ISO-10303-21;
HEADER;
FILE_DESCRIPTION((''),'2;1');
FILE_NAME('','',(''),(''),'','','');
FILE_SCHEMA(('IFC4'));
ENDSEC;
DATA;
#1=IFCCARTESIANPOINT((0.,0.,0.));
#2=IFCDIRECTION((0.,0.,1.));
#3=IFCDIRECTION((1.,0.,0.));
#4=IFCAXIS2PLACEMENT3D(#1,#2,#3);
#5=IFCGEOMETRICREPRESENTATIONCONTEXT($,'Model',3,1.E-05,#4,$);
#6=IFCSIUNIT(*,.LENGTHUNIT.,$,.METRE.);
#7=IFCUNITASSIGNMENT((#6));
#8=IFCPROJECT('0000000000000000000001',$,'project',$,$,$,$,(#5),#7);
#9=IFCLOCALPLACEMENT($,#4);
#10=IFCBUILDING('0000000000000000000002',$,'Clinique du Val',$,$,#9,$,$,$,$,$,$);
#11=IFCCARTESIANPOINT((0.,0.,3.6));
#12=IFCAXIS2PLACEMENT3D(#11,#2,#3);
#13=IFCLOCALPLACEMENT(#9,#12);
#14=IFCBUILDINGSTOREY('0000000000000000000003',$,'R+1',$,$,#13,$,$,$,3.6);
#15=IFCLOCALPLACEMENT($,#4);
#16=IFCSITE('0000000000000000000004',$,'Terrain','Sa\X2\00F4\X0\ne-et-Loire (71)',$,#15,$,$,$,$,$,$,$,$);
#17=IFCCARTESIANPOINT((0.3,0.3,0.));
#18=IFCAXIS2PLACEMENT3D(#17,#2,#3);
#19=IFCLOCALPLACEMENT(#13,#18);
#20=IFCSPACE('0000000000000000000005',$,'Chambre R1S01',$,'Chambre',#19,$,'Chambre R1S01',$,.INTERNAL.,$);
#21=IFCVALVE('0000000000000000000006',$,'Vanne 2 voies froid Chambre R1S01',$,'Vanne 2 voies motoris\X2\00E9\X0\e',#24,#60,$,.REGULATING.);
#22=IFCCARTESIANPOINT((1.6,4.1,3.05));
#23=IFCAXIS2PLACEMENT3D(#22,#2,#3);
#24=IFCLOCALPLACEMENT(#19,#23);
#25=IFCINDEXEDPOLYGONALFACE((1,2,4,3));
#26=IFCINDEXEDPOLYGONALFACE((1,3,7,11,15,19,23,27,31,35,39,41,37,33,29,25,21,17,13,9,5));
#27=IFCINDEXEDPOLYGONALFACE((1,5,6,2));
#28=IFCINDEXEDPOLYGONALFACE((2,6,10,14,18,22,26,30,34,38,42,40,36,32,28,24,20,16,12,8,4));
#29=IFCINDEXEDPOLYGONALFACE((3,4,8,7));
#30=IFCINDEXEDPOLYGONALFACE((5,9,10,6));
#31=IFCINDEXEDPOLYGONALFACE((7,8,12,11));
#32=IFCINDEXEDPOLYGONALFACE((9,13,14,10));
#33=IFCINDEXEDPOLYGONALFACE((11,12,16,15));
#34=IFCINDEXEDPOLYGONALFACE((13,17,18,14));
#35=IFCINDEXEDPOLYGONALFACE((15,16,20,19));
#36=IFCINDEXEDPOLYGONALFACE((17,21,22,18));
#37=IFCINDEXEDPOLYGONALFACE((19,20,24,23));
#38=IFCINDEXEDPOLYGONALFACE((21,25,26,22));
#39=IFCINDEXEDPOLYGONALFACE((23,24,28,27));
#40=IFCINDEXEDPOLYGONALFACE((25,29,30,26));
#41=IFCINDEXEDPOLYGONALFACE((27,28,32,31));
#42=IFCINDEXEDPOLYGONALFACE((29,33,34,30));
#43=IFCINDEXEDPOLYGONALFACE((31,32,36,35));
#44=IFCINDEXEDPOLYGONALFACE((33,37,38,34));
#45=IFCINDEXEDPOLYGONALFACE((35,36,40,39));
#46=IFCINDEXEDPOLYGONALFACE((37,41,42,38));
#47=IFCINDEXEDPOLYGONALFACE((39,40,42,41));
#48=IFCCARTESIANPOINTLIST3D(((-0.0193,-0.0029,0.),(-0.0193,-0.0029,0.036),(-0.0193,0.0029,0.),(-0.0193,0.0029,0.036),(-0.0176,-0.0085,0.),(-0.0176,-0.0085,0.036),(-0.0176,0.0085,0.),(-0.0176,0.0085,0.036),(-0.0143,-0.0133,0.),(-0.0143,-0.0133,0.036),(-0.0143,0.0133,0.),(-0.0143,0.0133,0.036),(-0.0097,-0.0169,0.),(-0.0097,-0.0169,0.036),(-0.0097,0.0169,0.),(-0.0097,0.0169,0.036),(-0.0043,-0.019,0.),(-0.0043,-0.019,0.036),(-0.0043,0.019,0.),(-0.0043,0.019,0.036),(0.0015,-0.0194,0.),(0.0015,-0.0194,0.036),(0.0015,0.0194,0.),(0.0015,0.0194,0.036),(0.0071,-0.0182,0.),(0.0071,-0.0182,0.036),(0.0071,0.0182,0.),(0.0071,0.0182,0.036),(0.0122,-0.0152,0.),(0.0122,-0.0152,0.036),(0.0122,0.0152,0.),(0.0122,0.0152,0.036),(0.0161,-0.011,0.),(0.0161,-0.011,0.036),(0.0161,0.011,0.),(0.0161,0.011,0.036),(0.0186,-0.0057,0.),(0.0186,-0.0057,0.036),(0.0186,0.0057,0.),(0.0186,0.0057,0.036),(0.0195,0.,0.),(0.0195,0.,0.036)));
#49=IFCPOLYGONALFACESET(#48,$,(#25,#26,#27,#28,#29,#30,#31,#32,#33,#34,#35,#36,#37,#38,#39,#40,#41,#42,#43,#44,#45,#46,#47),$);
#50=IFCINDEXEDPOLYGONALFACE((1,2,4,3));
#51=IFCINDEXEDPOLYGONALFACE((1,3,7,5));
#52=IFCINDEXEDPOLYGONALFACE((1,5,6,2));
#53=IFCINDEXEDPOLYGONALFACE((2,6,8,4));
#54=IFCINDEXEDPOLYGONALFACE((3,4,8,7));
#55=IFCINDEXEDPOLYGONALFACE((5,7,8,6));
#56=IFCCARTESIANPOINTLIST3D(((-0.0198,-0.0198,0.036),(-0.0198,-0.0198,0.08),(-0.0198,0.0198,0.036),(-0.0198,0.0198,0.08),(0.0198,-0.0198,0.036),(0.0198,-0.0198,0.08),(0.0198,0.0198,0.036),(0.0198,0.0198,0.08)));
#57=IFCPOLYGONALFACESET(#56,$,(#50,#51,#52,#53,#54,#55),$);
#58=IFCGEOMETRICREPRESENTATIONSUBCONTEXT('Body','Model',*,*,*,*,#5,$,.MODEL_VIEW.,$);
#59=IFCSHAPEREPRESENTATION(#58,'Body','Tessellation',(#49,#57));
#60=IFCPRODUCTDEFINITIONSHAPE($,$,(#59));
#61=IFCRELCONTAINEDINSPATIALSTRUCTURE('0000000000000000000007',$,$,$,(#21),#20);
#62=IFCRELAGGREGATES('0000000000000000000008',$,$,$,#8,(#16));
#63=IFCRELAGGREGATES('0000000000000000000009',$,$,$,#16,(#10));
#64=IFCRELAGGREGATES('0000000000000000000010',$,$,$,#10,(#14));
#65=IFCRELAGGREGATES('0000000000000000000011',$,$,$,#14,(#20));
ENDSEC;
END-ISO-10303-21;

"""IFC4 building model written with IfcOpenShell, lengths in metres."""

from ifc_helpers import new_model, si_unit, frame, frame_2d, origin_with_axes, place, context, subcontext, project, spatial, rectangle, circle, extrude, element, save


model = new_model("IFC4")

# Units and contexts
model_context = context("Model", 3, precision=1e-05, world=origin_with_axes())
body_context = subcontext(model_context, "Body", "Model", "MODEL_VIEW")
ifc_project = project(units=[si_unit("LENGTHUNIT", "METRE")], contexts=[model_context])

# Site, building, storey
site_placement = place(None, origin_with_axes())
site = spatial("IfcSite", under=ifc_project, at=site_placement, Name="Terrain", Description="Saône-et-Loire (71)")
building_placement = place(None, origin_with_axes())
building = spatial("IfcBuilding", under=site, at=building_placement, Name="Clinique du Val")
storey_placement = place(building_placement, frame((0.0, 0.0, 3.6), z_axis=(0.0, 0.0, 1.0), x_axis=(1.0, 0.0, 0.0)))
storey = spatial("IfcBuildingStorey", under=building, at=storey_placement, Name="R+1", Elevation=3.6)

# Shared definitions
space_1_placement = place(storey_placement, frame((0.3, 0.3, 0.0), z_axis=(0.0, 0.0, 1.0), x_axis=(1.0, 0.0, 0.0)))
space_1 = spatial("IfcSpace", under=storey, at=space_1_placement, Name="Chambre R1S01", ObjectType="Chambre", LongName="Chambre R1S01", PredefinedType="INTERNAL")

# Valve
valve_placement = place(space_1_placement, frame((1.6, 4.1, 3.05), z_axis=(0.0, 0.0, 1.0), x_axis=(1.0, 0.0, 0.0)))
element("IfcValve", 1, at=valve_placement, inside=space_1, Name="Vanne 2 voies froid Chambre R1S01", ObjectType="Vanne 2 voies motorisée", PredefinedType="REGULATING", context=body_context, shape_type="SweptSolid", body=[
    extrude(circle(Radius=0.0195), origin_with_axes(), (0.0, 0.0, 1.0), 0.036),
    extrude(rectangle(XDim=0.0396, YDim=0.0396, at=frame_2d((0.0198, 0.0198))), frame((-0.0198, -0.0198, 0.036), z_axis=(0.0, 0.0, 1.0), x_axis=(1.0, 0.0, 0.0)), (0.0, 0.0, 1.0), 0.044),
])

save(model, "model.ifc")
